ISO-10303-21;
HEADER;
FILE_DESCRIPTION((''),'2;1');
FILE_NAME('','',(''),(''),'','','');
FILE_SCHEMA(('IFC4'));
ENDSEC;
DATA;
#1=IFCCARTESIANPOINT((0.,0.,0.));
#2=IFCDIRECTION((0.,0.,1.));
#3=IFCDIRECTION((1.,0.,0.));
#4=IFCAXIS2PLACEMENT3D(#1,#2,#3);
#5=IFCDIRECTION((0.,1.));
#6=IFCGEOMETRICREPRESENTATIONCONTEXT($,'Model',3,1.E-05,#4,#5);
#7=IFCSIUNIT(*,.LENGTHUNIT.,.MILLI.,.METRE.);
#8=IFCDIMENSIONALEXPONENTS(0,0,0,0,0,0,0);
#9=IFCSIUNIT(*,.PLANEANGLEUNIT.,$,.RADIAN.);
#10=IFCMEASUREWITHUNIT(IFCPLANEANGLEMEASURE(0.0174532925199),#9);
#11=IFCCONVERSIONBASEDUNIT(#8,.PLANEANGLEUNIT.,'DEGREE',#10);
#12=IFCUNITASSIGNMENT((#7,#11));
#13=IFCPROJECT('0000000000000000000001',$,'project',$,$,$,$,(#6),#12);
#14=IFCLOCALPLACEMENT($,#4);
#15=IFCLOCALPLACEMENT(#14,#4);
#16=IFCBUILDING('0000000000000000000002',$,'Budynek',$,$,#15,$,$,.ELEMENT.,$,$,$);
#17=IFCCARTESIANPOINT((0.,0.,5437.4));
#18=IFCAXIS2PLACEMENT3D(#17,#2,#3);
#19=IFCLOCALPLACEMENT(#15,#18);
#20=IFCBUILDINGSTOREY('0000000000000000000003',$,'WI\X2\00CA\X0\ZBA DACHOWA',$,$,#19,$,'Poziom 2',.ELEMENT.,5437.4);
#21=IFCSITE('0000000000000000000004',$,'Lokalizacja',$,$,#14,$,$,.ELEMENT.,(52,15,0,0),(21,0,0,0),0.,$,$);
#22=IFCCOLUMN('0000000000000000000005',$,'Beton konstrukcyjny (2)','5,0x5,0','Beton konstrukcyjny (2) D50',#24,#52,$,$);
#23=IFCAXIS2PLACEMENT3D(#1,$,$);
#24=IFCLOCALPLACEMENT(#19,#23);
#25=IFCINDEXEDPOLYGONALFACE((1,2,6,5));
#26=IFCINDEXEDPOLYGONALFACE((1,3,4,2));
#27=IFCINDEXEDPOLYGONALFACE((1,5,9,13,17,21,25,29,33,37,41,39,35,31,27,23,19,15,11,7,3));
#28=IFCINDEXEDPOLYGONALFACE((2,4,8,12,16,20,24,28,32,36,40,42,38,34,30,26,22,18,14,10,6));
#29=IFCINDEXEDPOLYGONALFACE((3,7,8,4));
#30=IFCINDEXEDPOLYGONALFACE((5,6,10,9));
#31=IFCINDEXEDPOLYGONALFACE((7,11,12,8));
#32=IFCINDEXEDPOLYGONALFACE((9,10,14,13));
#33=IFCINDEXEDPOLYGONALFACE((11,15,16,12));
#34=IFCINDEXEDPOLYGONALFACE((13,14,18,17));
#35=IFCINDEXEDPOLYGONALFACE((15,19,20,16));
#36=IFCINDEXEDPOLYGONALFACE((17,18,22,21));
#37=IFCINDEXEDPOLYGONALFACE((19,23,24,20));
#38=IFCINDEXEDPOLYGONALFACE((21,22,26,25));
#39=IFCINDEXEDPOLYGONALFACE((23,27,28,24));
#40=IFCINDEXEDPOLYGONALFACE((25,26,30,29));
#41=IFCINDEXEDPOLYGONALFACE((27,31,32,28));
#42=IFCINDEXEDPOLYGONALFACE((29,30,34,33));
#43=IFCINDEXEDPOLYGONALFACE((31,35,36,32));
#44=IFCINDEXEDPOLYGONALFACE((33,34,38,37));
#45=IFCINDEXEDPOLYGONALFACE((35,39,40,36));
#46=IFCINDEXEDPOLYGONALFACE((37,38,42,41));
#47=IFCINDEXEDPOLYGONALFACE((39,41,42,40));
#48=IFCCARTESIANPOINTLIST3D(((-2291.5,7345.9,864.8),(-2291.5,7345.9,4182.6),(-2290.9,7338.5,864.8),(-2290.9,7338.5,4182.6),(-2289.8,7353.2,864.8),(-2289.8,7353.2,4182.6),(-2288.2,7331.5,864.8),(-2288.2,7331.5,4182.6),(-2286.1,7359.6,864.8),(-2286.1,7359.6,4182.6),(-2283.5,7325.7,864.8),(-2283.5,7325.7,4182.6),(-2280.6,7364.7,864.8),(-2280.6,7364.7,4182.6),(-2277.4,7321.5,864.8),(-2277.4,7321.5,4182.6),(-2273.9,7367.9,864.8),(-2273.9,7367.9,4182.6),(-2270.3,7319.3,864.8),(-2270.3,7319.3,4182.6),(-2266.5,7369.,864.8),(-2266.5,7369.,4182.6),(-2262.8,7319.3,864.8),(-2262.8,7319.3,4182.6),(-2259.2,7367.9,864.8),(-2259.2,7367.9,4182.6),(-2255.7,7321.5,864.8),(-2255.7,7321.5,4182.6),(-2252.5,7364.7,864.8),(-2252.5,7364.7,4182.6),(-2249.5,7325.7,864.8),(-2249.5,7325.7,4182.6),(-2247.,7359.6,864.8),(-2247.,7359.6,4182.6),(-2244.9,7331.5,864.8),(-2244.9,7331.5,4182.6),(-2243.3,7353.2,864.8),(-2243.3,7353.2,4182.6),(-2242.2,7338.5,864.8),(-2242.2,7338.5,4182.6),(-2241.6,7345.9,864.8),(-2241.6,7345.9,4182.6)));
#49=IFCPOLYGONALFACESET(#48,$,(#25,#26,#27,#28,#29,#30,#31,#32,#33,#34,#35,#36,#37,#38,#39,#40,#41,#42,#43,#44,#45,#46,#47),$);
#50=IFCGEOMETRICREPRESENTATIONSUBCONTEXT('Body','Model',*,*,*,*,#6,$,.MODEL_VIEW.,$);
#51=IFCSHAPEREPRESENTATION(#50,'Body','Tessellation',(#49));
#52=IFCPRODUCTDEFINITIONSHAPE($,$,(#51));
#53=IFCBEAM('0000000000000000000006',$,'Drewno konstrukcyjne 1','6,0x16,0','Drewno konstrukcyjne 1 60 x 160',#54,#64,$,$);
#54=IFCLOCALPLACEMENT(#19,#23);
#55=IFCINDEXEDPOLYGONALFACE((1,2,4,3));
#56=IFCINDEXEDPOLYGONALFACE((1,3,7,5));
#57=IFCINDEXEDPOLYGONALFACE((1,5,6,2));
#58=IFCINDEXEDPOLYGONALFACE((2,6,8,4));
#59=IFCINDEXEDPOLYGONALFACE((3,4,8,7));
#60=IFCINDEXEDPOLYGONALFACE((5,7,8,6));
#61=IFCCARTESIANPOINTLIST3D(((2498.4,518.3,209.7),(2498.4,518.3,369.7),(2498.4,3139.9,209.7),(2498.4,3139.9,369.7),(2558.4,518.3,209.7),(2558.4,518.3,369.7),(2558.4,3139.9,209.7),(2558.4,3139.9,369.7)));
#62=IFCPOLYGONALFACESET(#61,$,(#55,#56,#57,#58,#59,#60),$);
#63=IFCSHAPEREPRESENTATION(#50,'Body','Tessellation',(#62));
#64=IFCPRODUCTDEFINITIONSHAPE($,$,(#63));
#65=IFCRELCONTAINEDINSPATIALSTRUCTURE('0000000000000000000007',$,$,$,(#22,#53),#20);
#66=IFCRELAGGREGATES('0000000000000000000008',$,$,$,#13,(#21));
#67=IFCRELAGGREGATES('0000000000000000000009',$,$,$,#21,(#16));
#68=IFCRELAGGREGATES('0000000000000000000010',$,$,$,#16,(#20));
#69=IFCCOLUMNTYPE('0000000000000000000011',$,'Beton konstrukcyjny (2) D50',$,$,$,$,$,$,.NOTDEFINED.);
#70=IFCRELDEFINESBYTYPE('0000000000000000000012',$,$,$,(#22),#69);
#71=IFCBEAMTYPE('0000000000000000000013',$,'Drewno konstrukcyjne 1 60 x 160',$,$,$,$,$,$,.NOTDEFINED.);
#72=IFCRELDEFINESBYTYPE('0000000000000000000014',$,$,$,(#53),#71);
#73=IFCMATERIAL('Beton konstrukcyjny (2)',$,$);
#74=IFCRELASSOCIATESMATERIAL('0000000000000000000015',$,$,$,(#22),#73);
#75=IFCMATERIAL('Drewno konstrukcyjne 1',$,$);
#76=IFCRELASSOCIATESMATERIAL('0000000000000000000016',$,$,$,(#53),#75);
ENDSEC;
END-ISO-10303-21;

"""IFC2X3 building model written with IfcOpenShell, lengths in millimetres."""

from ifc_helpers import new_model, entity, si_unit, converted_unit, direction, frame, frame_2d, origin_with_axes, origin_2d_with_axis, place, context, subcontext, project, spatial, rectangle, circle, extrude, material, type_object, element, save


model = new_model("IFC2X3")

# Units and contexts
model_context = context("Model", 3, precision=1e-05, world=origin_with_axes(), true_north=direction((0.0, 1.0)))
body_context = subcontext(model_context, "Body", "Model", "MODEL_VIEW")
ifc_project = project(units=[si_unit("LENGTHUNIT", "METRE", prefix="MILLI"), converted_unit("PLANEANGLEUNIT", "DEGREE", entity("IfcPlaneAngleMeasure", 0.0174532925199), si_unit("PLANEANGLEUNIT", "RADIAN"), dimensions=[0, 0, 0, 0, 0, 0, 0])], contexts=[model_context])

# Site, building, storey
site_placement = place(None, origin_with_axes())
site = spatial("IfcSite", under=ifc_project, at=site_placement, Name="Lokalizacja", CompositionType="ELEMENT", RefLatitude=(52, 15, 0, 0), RefLongitude=(21, 0, 0, 0), RefElevation=0.0)
building_placement = place(site_placement, origin_with_axes())
building = spatial("IfcBuilding", under=site, at=building_placement, Name="Budynek", CompositionType="ELEMENT")
storey_placement = place(building_placement, frame((0.0, 0.0, 5437.4), z_axis=(0.0, 0.0, 1.0), x_axis=(1.0, 0.0, 0.0)))
storey = spatial("IfcBuildingStorey", under=building, at=storey_placement, Name="WIÊZBA DACHOWA", LongName="Poziom 2", CompositionType="ELEMENT", Elevation=5437.4)

# Column
ifc_material_1 = material(Name="Beton konstrukcyjny (2)")
column_type = type_object("IfcColumnType", Name="Beton konstrukcyjny (2) D50", PredefinedType="NOTDEFINED")
column_placement = place(storey_placement, frame((-2266.5, 7344.0, 864.8), z_axis=(0.0, 0.0, 1.0), x_axis=(0.0, 1.0, 0.0)))
element("IfcColumn", 1, at=column_placement, inside=storey, type_object=column_type, material=ifc_material_1, Name="Beton konstrukcyjny (2)", Description="5,0x5,0", ObjectType="Beton konstrukcyjny (2) D50", context=body_context, shape_type="SweptSolid", body=[
    extrude(circle(Radius=25.0, at=origin_2d_with_axis()), origin_with_axes(), (0.0, 0.0, 1.0), 3317.8),
])

# Beam
ifc_material_2 = material(Name="Drewno konstrukcyjne 1")
beam_type_1 = type_object("IfcBeamType", Name="Drewno konstrukcyjne 1 60 x 160", PredefinedType="NOTDEFINED")
beam_1_placement = place(storey_placement, frame((2528.4, 518.3, 369.7), z_axis=(0.0, 0.0, 1.0), x_axis=(1.0, 0.0, 0.0)))
element("IfcBeam", 2, at=beam_1_placement, inside=storey, type_object=beam_type_1, material=ifc_material_2, Name="Drewno konstrukcyjne 1", Description="6,0x16,0", ObjectType="Drewno konstrukcyjne 1 60 x 160", context=body_context, shape_type="SweptSolid", body=[
    extrude(rectangle(XDim=160.0, YDim=60.0, at=frame_2d((-80.0, 0.0), x_axis=(1.0, 0.0))), frame((0.0, 0.0, 0.0), z_axis=(0.0, 1.0, 0.0), x_axis=(0.0, 0.0, 1.0)), (0.0, 0.0, 1.0), 2621.6),
])

save(model, "model.ifc")
